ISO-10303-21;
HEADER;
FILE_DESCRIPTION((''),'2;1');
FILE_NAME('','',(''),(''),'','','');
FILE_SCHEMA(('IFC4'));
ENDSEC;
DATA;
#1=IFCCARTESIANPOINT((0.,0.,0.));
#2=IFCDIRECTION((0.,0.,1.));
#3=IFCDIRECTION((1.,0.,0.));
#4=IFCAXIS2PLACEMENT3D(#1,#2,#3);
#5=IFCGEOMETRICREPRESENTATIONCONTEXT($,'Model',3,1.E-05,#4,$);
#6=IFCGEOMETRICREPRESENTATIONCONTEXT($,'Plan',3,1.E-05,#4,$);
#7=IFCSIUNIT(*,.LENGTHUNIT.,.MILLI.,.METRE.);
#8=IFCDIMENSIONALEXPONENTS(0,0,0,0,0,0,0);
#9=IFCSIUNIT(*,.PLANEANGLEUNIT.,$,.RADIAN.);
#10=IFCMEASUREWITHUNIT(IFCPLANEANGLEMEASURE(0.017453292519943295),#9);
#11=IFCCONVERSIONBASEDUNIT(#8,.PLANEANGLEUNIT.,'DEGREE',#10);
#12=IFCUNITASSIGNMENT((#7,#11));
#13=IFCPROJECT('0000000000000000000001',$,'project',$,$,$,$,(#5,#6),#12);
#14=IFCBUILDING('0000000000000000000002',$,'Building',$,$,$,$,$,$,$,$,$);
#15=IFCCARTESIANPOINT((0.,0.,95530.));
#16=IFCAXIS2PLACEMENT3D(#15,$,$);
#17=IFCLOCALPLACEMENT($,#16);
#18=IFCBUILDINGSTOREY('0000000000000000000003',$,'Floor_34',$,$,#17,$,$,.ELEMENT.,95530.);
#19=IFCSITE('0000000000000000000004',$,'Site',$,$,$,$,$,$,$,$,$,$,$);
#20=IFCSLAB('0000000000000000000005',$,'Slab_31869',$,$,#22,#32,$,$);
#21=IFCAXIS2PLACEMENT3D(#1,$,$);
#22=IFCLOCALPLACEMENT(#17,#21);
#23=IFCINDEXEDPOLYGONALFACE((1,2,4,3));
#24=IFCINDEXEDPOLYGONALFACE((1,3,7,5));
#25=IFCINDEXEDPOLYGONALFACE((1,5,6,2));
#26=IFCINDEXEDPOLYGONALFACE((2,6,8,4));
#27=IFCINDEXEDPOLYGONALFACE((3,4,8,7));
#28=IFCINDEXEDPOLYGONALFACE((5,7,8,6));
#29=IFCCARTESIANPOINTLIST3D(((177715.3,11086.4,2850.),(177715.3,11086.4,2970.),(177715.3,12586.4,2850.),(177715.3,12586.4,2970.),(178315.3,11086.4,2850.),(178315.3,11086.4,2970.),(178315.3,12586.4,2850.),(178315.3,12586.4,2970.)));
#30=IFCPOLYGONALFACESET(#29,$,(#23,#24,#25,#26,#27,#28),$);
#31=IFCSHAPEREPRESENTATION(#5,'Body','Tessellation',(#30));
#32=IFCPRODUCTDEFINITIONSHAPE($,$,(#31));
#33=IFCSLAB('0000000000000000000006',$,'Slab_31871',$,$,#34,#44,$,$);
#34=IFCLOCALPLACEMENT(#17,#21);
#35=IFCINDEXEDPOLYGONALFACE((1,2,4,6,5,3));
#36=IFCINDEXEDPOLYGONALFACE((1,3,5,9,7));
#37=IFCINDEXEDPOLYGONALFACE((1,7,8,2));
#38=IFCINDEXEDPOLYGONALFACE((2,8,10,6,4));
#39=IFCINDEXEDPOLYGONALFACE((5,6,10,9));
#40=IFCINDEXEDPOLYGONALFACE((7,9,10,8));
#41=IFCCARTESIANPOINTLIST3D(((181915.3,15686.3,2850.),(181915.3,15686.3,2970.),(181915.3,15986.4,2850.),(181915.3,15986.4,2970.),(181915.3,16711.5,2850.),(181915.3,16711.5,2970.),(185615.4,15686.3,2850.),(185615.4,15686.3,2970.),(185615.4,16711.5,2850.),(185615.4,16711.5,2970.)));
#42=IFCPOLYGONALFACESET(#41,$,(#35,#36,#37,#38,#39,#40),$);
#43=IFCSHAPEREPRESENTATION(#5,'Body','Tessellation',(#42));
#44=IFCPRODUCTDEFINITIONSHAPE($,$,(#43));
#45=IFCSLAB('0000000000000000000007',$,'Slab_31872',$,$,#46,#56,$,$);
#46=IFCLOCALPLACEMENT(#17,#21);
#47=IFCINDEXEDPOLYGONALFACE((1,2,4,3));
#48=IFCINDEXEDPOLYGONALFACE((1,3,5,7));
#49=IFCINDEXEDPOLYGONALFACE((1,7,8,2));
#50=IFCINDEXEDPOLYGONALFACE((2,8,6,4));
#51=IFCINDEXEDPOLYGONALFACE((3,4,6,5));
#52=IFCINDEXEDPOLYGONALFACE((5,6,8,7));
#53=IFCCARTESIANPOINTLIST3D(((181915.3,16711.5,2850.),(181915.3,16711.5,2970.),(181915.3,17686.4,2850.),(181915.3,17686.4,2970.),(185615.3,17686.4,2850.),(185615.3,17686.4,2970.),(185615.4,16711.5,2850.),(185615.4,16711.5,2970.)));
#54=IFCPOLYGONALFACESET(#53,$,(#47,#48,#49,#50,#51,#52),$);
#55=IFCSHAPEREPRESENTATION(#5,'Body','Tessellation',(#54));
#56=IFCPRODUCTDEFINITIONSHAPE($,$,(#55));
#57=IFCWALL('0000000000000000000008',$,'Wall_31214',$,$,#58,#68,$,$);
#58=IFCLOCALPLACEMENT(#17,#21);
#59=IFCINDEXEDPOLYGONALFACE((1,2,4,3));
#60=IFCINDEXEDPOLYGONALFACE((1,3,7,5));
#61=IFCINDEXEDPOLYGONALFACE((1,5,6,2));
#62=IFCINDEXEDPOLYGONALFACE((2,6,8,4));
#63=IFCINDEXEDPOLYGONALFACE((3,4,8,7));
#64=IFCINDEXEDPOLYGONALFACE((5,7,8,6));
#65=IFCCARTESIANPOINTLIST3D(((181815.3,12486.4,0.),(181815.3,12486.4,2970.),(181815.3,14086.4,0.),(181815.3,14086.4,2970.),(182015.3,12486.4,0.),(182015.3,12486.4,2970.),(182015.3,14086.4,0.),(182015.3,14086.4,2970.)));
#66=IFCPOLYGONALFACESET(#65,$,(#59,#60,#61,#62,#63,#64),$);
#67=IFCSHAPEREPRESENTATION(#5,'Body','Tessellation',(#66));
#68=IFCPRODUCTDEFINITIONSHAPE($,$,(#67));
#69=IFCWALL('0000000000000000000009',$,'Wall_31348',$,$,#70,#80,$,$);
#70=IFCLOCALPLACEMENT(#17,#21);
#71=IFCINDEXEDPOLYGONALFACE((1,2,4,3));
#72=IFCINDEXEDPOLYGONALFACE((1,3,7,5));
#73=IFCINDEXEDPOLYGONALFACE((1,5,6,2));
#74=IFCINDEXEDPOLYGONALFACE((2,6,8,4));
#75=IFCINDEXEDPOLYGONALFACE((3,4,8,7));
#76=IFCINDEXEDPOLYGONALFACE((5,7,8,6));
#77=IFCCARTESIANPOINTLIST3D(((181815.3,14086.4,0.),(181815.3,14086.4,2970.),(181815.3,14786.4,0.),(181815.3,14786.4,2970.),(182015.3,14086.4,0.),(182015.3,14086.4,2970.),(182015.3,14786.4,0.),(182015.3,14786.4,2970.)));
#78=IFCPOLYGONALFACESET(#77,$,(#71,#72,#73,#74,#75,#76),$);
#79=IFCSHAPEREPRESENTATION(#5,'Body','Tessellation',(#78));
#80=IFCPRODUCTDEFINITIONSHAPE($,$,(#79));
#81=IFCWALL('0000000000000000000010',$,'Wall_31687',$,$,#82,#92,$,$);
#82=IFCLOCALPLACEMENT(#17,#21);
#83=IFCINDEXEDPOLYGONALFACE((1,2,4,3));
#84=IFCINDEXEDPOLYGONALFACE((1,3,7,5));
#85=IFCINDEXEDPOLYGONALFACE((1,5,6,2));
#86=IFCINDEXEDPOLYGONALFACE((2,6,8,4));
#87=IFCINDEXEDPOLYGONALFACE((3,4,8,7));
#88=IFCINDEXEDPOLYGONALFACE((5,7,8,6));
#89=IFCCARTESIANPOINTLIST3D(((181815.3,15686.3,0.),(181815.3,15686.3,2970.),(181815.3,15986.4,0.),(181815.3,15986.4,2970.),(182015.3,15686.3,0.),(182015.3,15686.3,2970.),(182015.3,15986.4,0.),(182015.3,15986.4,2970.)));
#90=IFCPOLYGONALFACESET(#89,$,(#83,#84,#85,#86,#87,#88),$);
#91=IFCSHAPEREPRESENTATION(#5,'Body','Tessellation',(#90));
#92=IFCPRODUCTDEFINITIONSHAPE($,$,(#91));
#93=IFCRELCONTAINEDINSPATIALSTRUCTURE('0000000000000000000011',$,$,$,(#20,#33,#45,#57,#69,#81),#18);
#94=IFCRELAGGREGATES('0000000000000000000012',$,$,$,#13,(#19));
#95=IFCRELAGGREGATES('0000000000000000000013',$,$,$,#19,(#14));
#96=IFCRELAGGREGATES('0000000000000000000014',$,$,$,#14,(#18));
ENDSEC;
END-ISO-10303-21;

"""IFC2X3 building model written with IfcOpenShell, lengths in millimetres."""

from ifc_helpers import new_model, entity, si_unit, converted_unit, frame, origin_with_axes, origin_2d, place, context, project, spatial, polyline, rectangle, outline, extrude, element, save


model = new_model("IFC2X3")

# Units and contexts
model_context = context("Model", 3, precision=1e-05, world=origin_with_axes())
plan_context = context("Plan", 3, precision=1e-05, world=origin_with_axes())
ifc_project = project(units=[si_unit("LENGTHUNIT", "METRE", prefix="MILLI"), converted_unit("PLANEANGLEUNIT", "DEGREE", entity("IfcPlaneAngleMeasure", 0.017453292519943295), si_unit("PLANEANGLEUNIT", "RADIAN"), dimensions=[0, 0, 0, 0, 0, 0, 0])], contexts=[model_context, plan_context])

# Site, building, storey
site = spatial("IfcSite", under=ifc_project, Name="Site")
building = spatial("IfcBuilding", under=site, Name="Building")
storey_placement = place(None, frame((0.0, 0.0, 95530.0)))
storey = spatial("IfcBuildingStorey", under=building, at=storey_placement, Name="Floor_34", CompositionType="ELEMENT", Elevation=95530.0)

# Slabs
slab_1_placement = place(storey_placement, frame((177715.3, 12586.4, 2850.0), z_axis=(0.0, 0.0, 1.0), x_axis=(0.0, -1500.0, 0.0)))
element("IfcSlab", 1, at=slab_1_placement, inside=storey, Name="Slab_31869", context=model_context, shape_type="SweptSolid", body=[
    extrude(outline(polyline([(0.0, 0.0), (1500.0, 0.0), (1500.0, 600.0), (0.0, 600.0)])), origin_with_axes(), (0.0, 0.0, 1.0), 120.0),
])
slab_2_placement = place(storey_placement, frame((181915.3, 16711.5, 2850.0), z_axis=(0.0, 0.0, 1.0), x_axis=(0.0, -725.123, 0.0)))
element("IfcSlab", 2, at=slab_2_placement, inside=storey, Name="Slab_31871", context=model_context, shape_type="SweptSolid", body=[
    extrude(outline(polyline([(0.0, 0.0), (725.1, 0.0), (1025.2, 0.0), (1025.2, 3700.0), (0.0, 3700.0)])), origin_with_axes(), (0.0, 0.0, 1.0), 120.0),
])
slab_3_placement = place(storey_placement, frame((181915.3, 17686.4, 2850.0), z_axis=(0.0, 0.0, 1.0), x_axis=(-0.002, -974.89, 0.0)))
element("IfcSlab", 3, at=slab_3_placement, inside=storey, Name="Slab_31872", context=model_context, shape_type="SweptSolid", body=[
    extrude(outline(polyline([(0.0, 0.0), (974.9, 0.0), (974.9, 3700.0), (0.0, 3700.0)])), origin_with_axes(), (0.0, 0.0, 1.0), 120.0),
])

# Walls
wall_1_placement = place(storey_placement, frame((181915.3, 13286.4, 0.0), z_axis=(0.0, 0.0, 1.0), x_axis=(0.0, 1600.000004, 0.0)))
element("IfcWall", 4, at=wall_1_placement, inside=storey, Name="Wall_31214", context=model_context, shape_type="SweptSolid", body=[
    extrude(rectangle(XDim=1600.0, YDim=200.0, at=origin_2d()), origin_with_axes(), (0.0, 0.0, 1.0), 2970.0),
])
wall_2_placement = place(storey_placement, frame((181915.3, 14436.4, 0.0), z_axis=(0.0, 0.0, 1.0), x_axis=(0.0, 700.0, 0.0)))
element("IfcWall", 5, at=wall_2_placement, inside=storey, Name="Wall_31348", context=model_context, shape_type="SweptSolid", body=[
    extrude(rectangle(XDim=700.0, YDim=200.0, at=origin_2d()), origin_with_axes(), (0.0, 0.0, 1.0), 2970.0),
])
wall_3_placement = place(storey_placement, frame((181915.3, 15836.3, 0.0), z_axis=(0.0, 0.0, 1.0), x_axis=(0.001579, 300.112741, 0.0)))
element("IfcWall", 6, at=wall_3_placement, inside=storey, Name="Wall_31687", context=model_context, shape_type="SweptSolid", body=[
    extrude(rectangle(XDim=300.1, YDim=200.0, at=origin_2d()), origin_with_axes(), (0.0, 0.0, 1.0), 2970.0),
])

save(model, "model.ifc")
